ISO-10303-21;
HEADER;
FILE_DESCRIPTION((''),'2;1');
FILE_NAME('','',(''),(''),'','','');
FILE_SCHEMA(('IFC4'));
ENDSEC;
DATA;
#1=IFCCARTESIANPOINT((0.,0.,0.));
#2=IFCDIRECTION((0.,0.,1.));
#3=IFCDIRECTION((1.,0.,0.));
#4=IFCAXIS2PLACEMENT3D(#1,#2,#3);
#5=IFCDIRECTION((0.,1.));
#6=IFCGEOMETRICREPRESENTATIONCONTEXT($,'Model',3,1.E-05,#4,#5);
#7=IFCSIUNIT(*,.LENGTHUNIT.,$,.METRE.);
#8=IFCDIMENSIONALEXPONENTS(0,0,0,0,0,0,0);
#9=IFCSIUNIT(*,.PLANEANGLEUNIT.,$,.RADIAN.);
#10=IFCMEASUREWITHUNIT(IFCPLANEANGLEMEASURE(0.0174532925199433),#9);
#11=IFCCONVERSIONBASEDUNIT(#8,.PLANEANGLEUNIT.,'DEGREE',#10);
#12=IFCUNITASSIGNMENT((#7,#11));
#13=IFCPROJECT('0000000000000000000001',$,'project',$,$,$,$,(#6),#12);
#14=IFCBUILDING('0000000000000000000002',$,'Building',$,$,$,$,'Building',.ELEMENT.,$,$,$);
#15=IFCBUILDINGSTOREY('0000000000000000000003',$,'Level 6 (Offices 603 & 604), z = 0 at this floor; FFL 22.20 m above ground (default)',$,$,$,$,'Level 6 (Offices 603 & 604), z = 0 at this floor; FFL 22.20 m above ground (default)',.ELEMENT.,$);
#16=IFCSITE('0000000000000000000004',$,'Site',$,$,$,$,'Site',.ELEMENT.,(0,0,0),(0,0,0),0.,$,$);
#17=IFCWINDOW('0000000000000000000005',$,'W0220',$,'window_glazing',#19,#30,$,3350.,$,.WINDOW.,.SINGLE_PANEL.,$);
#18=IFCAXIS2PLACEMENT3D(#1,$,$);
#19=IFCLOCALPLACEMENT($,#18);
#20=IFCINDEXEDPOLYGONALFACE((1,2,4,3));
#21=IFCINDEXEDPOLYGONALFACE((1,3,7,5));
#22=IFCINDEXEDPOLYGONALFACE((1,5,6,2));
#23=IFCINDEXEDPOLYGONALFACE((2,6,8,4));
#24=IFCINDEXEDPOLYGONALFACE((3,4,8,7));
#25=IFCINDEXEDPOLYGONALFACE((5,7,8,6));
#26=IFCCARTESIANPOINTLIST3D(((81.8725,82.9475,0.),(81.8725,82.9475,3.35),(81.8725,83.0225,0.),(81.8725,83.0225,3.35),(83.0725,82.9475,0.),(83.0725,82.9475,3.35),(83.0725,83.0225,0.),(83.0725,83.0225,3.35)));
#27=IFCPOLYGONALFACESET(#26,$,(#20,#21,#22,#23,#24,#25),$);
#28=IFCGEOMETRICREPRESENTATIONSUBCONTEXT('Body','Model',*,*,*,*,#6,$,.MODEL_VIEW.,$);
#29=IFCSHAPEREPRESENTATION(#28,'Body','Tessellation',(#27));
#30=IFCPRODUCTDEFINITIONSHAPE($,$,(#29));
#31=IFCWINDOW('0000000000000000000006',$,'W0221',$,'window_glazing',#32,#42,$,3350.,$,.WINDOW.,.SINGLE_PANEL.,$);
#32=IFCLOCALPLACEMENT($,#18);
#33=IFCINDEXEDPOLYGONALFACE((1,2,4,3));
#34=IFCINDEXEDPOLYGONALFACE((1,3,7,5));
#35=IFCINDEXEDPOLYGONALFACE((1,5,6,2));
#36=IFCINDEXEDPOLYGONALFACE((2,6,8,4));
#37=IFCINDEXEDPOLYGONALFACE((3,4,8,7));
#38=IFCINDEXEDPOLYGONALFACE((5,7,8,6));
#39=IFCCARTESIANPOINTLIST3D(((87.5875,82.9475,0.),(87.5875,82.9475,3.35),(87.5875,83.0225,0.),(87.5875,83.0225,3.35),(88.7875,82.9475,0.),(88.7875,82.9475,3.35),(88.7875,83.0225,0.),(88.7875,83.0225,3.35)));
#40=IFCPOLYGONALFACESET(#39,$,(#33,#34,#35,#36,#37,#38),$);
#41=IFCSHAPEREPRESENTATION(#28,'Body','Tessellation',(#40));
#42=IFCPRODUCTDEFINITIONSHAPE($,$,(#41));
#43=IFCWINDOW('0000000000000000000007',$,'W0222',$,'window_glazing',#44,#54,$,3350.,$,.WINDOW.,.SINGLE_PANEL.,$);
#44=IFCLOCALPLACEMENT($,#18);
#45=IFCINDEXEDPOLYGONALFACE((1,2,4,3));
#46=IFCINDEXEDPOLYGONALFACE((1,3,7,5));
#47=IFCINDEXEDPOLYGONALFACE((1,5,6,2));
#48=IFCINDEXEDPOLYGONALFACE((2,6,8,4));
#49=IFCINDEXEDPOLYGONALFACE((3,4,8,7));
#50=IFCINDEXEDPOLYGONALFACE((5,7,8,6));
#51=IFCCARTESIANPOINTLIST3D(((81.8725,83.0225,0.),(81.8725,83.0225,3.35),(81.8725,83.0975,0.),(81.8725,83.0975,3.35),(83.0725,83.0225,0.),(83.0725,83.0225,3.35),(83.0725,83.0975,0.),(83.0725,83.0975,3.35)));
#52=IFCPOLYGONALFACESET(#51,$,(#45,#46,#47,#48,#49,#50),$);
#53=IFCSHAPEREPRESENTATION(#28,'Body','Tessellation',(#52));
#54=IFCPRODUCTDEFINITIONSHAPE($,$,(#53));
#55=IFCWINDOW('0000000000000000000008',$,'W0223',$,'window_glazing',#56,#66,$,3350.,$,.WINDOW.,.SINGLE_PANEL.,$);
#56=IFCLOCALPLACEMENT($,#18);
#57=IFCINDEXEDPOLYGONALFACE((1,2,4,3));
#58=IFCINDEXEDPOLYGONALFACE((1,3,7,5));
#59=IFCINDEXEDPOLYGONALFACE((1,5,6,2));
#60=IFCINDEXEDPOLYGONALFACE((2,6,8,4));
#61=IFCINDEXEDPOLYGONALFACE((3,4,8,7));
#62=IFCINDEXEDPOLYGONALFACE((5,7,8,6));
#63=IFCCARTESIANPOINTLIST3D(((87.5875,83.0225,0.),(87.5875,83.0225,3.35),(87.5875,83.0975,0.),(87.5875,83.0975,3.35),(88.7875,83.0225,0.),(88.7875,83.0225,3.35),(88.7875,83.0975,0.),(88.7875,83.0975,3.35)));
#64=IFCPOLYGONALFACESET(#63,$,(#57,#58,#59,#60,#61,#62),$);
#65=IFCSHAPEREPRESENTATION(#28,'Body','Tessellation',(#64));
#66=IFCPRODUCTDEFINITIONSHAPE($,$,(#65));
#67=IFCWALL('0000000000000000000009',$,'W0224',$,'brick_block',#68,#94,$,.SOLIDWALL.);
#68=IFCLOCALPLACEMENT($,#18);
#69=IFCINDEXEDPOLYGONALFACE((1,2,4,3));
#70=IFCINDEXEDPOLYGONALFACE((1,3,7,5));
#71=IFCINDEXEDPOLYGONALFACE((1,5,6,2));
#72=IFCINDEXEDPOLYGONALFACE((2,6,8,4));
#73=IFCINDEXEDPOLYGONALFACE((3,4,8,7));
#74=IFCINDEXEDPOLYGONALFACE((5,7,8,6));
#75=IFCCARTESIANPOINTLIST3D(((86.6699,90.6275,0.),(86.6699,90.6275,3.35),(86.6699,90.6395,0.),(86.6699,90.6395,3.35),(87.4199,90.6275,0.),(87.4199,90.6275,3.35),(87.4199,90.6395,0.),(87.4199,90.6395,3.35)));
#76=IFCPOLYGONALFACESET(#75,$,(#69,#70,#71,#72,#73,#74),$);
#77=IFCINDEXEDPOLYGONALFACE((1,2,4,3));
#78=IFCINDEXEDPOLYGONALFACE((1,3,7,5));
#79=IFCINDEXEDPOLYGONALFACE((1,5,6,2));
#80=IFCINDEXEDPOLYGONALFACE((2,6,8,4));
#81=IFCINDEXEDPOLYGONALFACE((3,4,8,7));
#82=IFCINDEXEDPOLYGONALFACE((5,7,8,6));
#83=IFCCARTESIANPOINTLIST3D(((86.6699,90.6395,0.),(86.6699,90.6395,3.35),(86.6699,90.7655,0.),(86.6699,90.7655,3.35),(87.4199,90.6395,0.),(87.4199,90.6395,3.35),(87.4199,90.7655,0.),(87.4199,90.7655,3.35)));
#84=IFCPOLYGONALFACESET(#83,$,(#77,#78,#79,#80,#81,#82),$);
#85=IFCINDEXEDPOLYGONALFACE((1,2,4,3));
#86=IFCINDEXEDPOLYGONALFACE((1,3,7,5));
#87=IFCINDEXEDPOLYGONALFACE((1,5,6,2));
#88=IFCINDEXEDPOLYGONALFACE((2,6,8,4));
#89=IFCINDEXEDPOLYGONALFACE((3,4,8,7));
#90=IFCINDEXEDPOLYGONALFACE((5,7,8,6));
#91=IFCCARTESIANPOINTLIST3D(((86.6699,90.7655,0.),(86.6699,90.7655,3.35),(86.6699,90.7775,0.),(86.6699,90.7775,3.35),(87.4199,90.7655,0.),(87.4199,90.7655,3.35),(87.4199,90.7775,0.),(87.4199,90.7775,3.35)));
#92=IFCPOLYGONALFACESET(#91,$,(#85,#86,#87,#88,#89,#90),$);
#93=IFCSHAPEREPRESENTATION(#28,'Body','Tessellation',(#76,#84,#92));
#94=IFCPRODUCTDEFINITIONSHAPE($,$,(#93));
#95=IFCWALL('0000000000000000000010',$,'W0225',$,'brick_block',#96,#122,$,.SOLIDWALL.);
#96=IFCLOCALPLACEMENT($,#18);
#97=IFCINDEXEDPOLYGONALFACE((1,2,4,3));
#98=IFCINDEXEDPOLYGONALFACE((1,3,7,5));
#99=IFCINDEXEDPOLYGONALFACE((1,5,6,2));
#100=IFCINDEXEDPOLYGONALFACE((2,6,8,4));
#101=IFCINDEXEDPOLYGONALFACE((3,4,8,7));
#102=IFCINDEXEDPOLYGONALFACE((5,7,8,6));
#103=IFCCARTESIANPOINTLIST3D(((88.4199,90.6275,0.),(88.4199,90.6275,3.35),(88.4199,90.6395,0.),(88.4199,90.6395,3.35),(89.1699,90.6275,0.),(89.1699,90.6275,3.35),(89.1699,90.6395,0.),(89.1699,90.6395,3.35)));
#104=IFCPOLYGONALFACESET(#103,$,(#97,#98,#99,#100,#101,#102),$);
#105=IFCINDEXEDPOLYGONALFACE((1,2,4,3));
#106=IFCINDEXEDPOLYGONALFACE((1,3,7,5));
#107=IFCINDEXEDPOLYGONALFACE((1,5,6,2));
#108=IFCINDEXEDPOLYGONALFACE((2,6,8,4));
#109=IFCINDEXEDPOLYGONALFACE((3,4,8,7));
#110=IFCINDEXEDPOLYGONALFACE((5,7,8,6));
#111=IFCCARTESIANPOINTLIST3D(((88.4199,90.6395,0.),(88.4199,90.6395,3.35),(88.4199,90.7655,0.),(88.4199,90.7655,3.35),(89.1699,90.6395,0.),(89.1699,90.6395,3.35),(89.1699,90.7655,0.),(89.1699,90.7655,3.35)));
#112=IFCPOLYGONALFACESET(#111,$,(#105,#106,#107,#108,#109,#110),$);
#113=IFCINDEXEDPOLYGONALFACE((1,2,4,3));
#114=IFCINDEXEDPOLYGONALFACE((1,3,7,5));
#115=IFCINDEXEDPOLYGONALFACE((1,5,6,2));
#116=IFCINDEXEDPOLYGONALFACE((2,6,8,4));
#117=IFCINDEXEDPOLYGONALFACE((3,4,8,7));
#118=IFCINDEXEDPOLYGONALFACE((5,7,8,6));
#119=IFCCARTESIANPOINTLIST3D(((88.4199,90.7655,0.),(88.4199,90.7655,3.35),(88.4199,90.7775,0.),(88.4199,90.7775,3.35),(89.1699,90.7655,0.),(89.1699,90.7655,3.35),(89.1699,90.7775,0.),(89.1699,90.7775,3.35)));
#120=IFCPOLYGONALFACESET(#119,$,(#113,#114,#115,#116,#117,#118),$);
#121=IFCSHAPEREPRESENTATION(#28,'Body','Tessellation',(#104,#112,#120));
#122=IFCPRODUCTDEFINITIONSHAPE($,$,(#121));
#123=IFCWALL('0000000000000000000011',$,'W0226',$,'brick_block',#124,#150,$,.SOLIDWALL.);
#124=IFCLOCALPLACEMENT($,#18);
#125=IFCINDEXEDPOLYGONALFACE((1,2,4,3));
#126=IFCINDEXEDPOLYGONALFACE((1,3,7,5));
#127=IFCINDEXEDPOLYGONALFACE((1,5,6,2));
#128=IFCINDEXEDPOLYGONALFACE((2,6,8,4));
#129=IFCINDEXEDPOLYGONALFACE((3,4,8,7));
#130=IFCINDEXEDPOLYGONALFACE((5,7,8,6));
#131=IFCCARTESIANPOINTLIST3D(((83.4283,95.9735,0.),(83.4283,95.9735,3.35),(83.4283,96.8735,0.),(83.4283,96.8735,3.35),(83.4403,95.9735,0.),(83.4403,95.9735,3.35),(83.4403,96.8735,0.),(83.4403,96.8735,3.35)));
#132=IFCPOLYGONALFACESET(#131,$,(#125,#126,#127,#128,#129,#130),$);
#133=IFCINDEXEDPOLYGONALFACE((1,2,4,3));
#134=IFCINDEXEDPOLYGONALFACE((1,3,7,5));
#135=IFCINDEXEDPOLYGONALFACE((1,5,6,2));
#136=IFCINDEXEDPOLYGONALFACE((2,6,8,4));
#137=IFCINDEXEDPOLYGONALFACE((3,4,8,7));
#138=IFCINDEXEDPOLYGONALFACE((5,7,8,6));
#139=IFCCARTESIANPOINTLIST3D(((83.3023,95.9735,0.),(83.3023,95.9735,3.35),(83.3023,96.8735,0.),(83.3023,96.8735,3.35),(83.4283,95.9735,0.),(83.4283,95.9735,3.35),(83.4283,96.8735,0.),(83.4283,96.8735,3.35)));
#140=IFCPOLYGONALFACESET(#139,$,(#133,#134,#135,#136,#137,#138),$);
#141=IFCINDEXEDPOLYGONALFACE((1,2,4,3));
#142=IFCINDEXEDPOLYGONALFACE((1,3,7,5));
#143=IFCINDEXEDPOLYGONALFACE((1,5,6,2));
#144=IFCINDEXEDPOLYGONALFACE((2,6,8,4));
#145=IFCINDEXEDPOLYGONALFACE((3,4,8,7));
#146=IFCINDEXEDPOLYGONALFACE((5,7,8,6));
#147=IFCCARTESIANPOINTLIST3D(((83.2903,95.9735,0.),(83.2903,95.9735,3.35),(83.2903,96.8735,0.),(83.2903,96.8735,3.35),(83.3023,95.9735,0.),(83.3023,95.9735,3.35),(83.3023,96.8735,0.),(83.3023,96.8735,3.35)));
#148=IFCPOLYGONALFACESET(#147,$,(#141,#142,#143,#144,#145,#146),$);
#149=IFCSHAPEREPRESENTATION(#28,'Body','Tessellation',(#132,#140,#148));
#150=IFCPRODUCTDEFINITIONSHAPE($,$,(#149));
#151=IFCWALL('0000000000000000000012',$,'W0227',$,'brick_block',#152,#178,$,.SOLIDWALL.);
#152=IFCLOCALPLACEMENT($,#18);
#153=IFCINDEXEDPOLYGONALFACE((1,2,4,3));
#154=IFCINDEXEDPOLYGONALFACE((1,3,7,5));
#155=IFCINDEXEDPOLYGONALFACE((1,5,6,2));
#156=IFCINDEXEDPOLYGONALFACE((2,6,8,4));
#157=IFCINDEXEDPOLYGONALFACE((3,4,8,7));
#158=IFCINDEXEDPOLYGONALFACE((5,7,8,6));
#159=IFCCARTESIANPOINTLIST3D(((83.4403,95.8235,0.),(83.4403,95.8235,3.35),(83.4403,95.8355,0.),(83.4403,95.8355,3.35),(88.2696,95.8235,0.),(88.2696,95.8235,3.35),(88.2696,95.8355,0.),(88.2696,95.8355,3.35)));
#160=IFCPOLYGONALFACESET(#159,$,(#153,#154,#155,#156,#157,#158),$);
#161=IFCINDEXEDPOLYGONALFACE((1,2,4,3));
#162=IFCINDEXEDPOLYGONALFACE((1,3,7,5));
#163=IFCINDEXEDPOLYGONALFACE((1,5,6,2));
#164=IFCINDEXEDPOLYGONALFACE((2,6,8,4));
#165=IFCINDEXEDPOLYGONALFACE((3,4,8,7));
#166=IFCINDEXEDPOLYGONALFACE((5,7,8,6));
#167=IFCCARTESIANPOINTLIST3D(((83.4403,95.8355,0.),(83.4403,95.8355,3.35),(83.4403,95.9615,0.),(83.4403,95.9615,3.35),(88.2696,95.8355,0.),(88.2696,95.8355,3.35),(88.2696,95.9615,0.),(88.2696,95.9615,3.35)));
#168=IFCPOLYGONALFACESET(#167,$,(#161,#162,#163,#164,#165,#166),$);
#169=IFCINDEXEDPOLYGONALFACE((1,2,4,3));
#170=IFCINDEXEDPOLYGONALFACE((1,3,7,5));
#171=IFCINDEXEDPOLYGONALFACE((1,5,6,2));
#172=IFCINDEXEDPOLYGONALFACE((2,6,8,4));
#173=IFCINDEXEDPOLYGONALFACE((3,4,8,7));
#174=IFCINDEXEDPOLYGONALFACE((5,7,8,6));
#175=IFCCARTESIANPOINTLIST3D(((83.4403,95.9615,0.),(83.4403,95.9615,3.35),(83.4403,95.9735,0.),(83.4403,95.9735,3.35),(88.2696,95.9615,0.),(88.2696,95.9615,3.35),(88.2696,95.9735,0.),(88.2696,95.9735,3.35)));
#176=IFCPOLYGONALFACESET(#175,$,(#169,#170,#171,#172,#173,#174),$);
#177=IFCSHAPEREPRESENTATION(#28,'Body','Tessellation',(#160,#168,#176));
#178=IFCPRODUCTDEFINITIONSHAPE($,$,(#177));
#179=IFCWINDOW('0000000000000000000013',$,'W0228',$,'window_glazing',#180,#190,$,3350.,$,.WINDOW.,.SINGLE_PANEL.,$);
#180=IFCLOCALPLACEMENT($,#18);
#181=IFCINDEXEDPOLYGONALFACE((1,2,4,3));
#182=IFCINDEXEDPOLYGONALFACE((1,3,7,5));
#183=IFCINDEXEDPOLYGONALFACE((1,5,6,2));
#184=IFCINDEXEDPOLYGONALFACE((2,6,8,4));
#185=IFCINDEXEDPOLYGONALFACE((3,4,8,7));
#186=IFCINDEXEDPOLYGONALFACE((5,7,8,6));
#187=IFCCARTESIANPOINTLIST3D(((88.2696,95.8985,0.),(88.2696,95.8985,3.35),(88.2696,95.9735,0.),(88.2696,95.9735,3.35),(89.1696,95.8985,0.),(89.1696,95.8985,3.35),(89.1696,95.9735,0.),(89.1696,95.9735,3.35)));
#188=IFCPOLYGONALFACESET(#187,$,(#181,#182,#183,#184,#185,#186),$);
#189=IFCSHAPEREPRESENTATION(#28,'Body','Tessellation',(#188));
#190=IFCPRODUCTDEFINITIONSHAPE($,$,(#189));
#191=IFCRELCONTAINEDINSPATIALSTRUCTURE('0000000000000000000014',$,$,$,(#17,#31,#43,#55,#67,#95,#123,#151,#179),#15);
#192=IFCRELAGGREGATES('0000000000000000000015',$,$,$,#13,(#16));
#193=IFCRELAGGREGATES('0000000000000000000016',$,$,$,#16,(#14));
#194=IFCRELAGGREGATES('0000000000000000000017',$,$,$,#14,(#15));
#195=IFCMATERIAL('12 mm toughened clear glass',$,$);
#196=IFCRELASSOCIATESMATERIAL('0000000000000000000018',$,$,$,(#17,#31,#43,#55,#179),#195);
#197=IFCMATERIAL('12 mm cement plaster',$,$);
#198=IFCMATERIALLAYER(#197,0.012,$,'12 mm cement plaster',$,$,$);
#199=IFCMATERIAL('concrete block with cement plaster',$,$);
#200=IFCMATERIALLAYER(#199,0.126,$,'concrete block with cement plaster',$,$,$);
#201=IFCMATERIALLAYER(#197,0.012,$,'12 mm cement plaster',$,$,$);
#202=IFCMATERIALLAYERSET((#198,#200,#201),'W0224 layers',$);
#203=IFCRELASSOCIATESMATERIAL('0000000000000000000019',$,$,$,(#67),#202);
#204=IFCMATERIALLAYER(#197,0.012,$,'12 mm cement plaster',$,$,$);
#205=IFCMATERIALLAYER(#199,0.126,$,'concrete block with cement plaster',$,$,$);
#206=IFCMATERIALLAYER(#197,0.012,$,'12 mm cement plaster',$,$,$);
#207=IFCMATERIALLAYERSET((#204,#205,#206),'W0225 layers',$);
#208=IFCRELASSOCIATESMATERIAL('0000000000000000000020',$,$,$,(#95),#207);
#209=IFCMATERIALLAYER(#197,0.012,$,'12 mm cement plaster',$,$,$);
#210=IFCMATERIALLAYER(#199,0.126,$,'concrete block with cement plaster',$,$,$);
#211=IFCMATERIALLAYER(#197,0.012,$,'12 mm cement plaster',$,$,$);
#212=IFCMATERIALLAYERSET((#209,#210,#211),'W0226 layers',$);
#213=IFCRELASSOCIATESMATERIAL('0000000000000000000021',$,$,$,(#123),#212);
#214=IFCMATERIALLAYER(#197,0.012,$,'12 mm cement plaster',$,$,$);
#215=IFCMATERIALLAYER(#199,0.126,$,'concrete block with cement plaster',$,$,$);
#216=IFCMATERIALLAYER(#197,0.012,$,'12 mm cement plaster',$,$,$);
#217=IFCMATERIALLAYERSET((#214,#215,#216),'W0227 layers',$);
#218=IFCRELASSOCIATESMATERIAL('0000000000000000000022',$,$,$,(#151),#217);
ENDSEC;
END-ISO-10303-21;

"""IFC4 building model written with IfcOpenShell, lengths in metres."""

from ifc_helpers import new_model, entity, si_unit, converted_unit, direction, frame, frame_2d, origin_with_axes, origin_2d_with_axis, place, context, subcontext, project, spatial, rectangle, extrude, material, layer, layer_set, layer_usage, element, save


model = new_model("IFC4")

# Units and contexts
model_context = context("Model", 3, precision=1e-05, world=origin_with_axes(), true_north=direction((0.0, 1.0)))
body_context = subcontext(model_context, "Body", "Model", "MODEL_VIEW")
ifc_project = project(units=[si_unit("LENGTHUNIT", "METRE"), converted_unit("PLANEANGLEUNIT", "DEGREE", entity("IfcPlaneAngleMeasure", 0.0174532925199433), si_unit("PLANEANGLEUNIT", "RADIAN"), dimensions=[0, 0, 0, 0, 0, 0, 0])], contexts=[model_context])

# Site, building, storey
site = spatial("IfcSite", under=ifc_project, Name="Site", LongName="Site", CompositionType="ELEMENT", RefLatitude=(0, 0, 0), RefLongitude=(0, 0, 0), RefElevation=0.0)
building = spatial("IfcBuilding", under=site, Name="Building", LongName="Building", CompositionType="ELEMENT")
storey = spatial("IfcBuildingStorey", under=building, Name="Level 6 (Offices 603 & 604), z = 0 at this floor; FFL 22.20 m above ground (default)", LongName="Level 6 (Offices 603 & 604), z = 0 at this floor; FFL 22.20 m above ground (default)", CompositionType="ELEMENT")

# Windows
ifc_material_1 = material(Name="12 mm toughened clear glass")
placement = place(None, origin_with_axes())
element("IfcWindow", 1, at=placement, inside=storey, material=ifc_material_1, Name="W0220", ObjectType="window_glazing", OverallHeight=3350.0, PartitioningType="SINGLE_PANEL", PredefinedType="WINDOW", context=body_context, shape_type="SweptSolid", body=[
    extrude(rectangle(XDim=1.2, YDim=0.075, at=frame_2d((0.0, 0.0), x_axis=(1.0, 0.0))), frame((82.4725, 82.985, 0.0), z_axis=(0.0, 0.0, 1.0), x_axis=(1.0, 0.0, 0.0)), (0.0, 0.0, 1.0), 3.35),
])
element("IfcWindow", 2, at=placement, inside=storey, material=ifc_material_1, Name="W0221", ObjectType="window_glazing", OverallHeight=3350.0, PartitioningType="SINGLE_PANEL", PredefinedType="WINDOW", context=body_context, shape_type="SweptSolid", body=[
    extrude(rectangle(XDim=1.2, YDim=0.075, at=frame_2d((0.0, 0.0), x_axis=(1.0, 0.0))), frame((88.1875, 82.985, 0.0), z_axis=(0.0, 0.0, 1.0), x_axis=(1.0, 0.0, 0.0)), (0.0, 0.0, 1.0), 3.35),
])
element("IfcWindow", 3, at=placement, inside=storey, material=ifc_material_1, Name="W0222", ObjectType="window_glazing", OverallHeight=3350.0, PartitioningType="SINGLE_PANEL", PredefinedType="WINDOW", context=body_context, shape_type="SweptSolid", body=[
    extrude(rectangle(XDim=1.2, YDim=0.075, at=frame_2d((0.0, 0.0), x_axis=(1.0, 0.0))), frame((82.4725, 83.06, 0.0), z_axis=(0.0, 0.0, 1.0), x_axis=(1.0, 0.0, 0.0)), (0.0, 0.0, 1.0), 3.35),
])
element("IfcWindow", 4, at=placement, inside=storey, material=ifc_material_1, Name="W0223", ObjectType="window_glazing", OverallHeight=3350.0, PartitioningType="SINGLE_PANEL", PredefinedType="WINDOW", context=body_context, shape_type="SweptSolid", body=[
    extrude(rectangle(XDim=1.2, YDim=0.075, at=frame_2d((0.0, 0.0), x_axis=(1.0, 0.0))), frame((88.1875, 83.06, 0.0), z_axis=(0.0, 0.0, 1.0), x_axis=(1.0, 0.0, 0.0)), (0.0, 0.0, 1.0), 3.35),
])

# Walls
ifc_material_2 = material(Name="12 mm cement plaster")
ifc_layer_1 = layer(ifc_material_2, 0.012, Name="12 mm cement plaster")
ifc_material_3 = material(Name="concrete block with cement plaster")
ifc_layer_2 = layer(ifc_material_3, 0.126, Name="concrete block with cement plaster")
ifc_layer_3 = layer(ifc_material_2, 0.012, Name="12 mm cement plaster")
ifc_layer_set_1 = layer_set([ifc_layer_1, ifc_layer_2, ifc_layer_3], Name="W0224 layers")
ifc_layer_usage_1 = layer_usage(ifc_layer_set_1, "AXIS2", "POSITIVE", -0.075)
element("IfcWall", 5, at=placement, inside=storey, material=ifc_layer_usage_1, Name="W0224", ObjectType="brick_block", PredefinedType="SOLIDWALL", context=body_context, shape_type="SweptSolid", body=[
    extrude(rectangle(XDim=0.75, YDim=0.012, at=origin_2d_with_axis()), frame((87.0449, 90.6335, 0.0), z_axis=(0.0, 0.0, 1.0), x_axis=(1.0, 0.0, 0.0)), (0.0, 0.0, 1.0), 3.35),
    extrude(rectangle(XDim=0.75, YDim=0.126, at=frame_2d((0.0, 0.069), x_axis=(1.0, 0.0))), frame((87.0449, 90.6335, 0.0), z_axis=(0.0, 0.0, 1.0), x_axis=(1.0, 0.0, 0.0)), (0.0, 0.0, 1.0), 3.35),
    extrude(rectangle(XDim=0.75, YDim=0.012, at=frame_2d((0.0, 0.138), x_axis=(1.0, 0.0))), frame((87.0449, 90.6335, 0.0), z_axis=(0.0, 0.0, 1.0), x_axis=(1.0, 0.0, 0.0)), (0.0, 0.0, 1.0), 3.35),
])
ifc_layer_4 = layer(ifc_material_2, 0.012, Name="12 mm cement plaster")
ifc_layer_5 = layer(ifc_material_3, 0.126, Name="concrete block with cement plaster")
ifc_layer_6 = layer(ifc_material_2, 0.012, Name="12 mm cement plaster")
ifc_layer_set_2 = layer_set([ifc_layer_4, ifc_layer_5, ifc_layer_6], Name="W0225 layers")
ifc_layer_usage_2 = layer_usage(ifc_layer_set_2, "AXIS2", "POSITIVE", -0.075)
element("IfcWall", 6, at=placement, inside=storey, material=ifc_layer_usage_2, Name="W0225", ObjectType="brick_block", PredefinedType="SOLIDWALL", context=body_context, shape_type="SweptSolid", body=[
    extrude(rectangle(XDim=0.75, YDim=0.012, at=origin_2d_with_axis()), frame((88.7949, 90.6335, 0.0), z_axis=(0.0, 0.0, 1.0), x_axis=(1.0, 0.0, 0.0)), (0.0, 0.0, 1.0), 3.35),
    extrude(rectangle(XDim=0.75, YDim=0.126, at=frame_2d((0.0, 0.069), x_axis=(1.0, 0.0))), frame((88.7949, 90.6335, 0.0), z_axis=(0.0, 0.0, 1.0), x_axis=(1.0, 0.0, 0.0)), (0.0, 0.0, 1.0), 3.35),
    extrude(rectangle(XDim=0.75, YDim=0.012, at=frame_2d((0.0, 0.138), x_axis=(1.0, 0.0))), frame((88.7949, 90.6335, 0.0), z_axis=(0.0, 0.0, 1.0), x_axis=(1.0, 0.0, 0.0)), (0.0, 0.0, 1.0), 3.35),
])
ifc_layer_7 = layer(ifc_material_2, 0.012, Name="12 mm cement plaster")
ifc_layer_8 = layer(ifc_material_3, 0.126, Name="concrete block with cement plaster")
ifc_layer_9 = layer(ifc_material_2, 0.012, Name="12 mm cement plaster")
ifc_layer_set_3 = layer_set([ifc_layer_7, ifc_layer_8, ifc_layer_9], Name="W0226 layers")
ifc_layer_usage_3 = layer_usage(ifc_layer_set_3, "AXIS2", "POSITIVE", -0.075)
element("IfcWall", 7, at=placement, inside=storey, material=ifc_layer_usage_3, Name="W0226", ObjectType="brick_block", PredefinedType="SOLIDWALL", context=body_context, shape_type="SweptSolid", body=[
    extrude(rectangle(XDim=0.9, YDim=0.012, at=frame_2d((0.0, 0.0), x_axis=(0.0, 1.0))), frame((83.4343, 96.4235, 0.0), z_axis=(0.0, 0.0, 1.0), x_axis=(1.0, 0.0, 0.0)), (0.0, 0.0, 1.0), 3.35),
    extrude(rectangle(XDim=0.9, YDim=0.126, at=frame_2d((-0.069, 0.0), x_axis=(0.0, 1.0))), frame((83.4343, 96.4235, 0.0), z_axis=(0.0, 0.0, 1.0), x_axis=(1.0, 0.0, 0.0)), (0.0, 0.0, 1.0), 3.35),
    extrude(rectangle(XDim=0.9, YDim=0.012, at=frame_2d((-0.138, 0.0), x_axis=(0.0, 1.0))), frame((83.4343, 96.4235, 0.0), z_axis=(0.0, 0.0, 1.0), x_axis=(1.0, 0.0, 0.0)), (0.0, 0.0, 1.0), 3.35),
])
ifc_layer_10 = layer(ifc_material_2, 0.012, Name="12 mm cement plaster")
ifc_layer_11 = layer(ifc_material_3, 0.126, Name="concrete block with cement plaster")
ifc_layer_12 = layer(ifc_material_2, 0.012, Name="12 mm cement plaster")
ifc_layer_set_4 = layer_set([ifc_layer_10, ifc_layer_11, ifc_layer_12], Name="W0227 layers")
ifc_layer_usage_4 = layer_usage(ifc_layer_set_4, "AXIS2", "POSITIVE", -0.075)
element("IfcWall", 8, at=placement, inside=storey, material=ifc_layer_usage_4, Name="W0227", ObjectType="brick_block", PredefinedType="SOLIDWALL", context=body_context, shape_type="SweptSolid", body=[
    extrude(rectangle(XDim=4.8293, YDim=0.012, at=frame_2d((0.0, 0.0), x_axis=(1.0, 0.0))), frame((85.855, 95.8295, 0.0), z_axis=(0.0, 0.0, 1.0), x_axis=(1.0, 0.0, 0.0)), (0.0, 0.0, 1.0), 3.35),
    extrude(rectangle(XDim=4.8293, YDim=0.126, at=frame_2d((0.0, 0.069), x_axis=(1.0, 0.0))), frame((85.855, 95.8295, 0.0), z_axis=(0.0, 0.0, 1.0), x_axis=(1.0, 0.0, 0.0)), (0.0, 0.0, 1.0), 3.35),
    extrude(rectangle(XDim=4.8293, YDim=0.012, at=frame_2d((0.0, 0.138), x_axis=(1.0, 0.0))), frame((85.855, 95.8295, 0.0), z_axis=(0.0, 0.0, 1.0), x_axis=(1.0, 0.0, 0.0)), (0.0, 0.0, 1.0), 3.35),
])

# Window
element("IfcWindow", 9, at=placement, inside=storey, material=ifc_material_1, Name="W0228", ObjectType="window_glazing", OverallHeight=3350.0, PartitioningType="SINGLE_PANEL", PredefinedType="WINDOW", context=body_context, shape_type="SweptSolid", body=[
    extrude(rectangle(XDim=0.9, YDim=0.075, at=frame_2d((0.0, 0.0), x_axis=(1.0, 0.0))), frame((88.7196, 95.936, 0.0), z_axis=(0.0, 0.0, 1.0), x_axis=(1.0, 0.0, 0.0)), (0.0, 0.0, 1.0), 3.35),
])

save(model, "model.ifc")
